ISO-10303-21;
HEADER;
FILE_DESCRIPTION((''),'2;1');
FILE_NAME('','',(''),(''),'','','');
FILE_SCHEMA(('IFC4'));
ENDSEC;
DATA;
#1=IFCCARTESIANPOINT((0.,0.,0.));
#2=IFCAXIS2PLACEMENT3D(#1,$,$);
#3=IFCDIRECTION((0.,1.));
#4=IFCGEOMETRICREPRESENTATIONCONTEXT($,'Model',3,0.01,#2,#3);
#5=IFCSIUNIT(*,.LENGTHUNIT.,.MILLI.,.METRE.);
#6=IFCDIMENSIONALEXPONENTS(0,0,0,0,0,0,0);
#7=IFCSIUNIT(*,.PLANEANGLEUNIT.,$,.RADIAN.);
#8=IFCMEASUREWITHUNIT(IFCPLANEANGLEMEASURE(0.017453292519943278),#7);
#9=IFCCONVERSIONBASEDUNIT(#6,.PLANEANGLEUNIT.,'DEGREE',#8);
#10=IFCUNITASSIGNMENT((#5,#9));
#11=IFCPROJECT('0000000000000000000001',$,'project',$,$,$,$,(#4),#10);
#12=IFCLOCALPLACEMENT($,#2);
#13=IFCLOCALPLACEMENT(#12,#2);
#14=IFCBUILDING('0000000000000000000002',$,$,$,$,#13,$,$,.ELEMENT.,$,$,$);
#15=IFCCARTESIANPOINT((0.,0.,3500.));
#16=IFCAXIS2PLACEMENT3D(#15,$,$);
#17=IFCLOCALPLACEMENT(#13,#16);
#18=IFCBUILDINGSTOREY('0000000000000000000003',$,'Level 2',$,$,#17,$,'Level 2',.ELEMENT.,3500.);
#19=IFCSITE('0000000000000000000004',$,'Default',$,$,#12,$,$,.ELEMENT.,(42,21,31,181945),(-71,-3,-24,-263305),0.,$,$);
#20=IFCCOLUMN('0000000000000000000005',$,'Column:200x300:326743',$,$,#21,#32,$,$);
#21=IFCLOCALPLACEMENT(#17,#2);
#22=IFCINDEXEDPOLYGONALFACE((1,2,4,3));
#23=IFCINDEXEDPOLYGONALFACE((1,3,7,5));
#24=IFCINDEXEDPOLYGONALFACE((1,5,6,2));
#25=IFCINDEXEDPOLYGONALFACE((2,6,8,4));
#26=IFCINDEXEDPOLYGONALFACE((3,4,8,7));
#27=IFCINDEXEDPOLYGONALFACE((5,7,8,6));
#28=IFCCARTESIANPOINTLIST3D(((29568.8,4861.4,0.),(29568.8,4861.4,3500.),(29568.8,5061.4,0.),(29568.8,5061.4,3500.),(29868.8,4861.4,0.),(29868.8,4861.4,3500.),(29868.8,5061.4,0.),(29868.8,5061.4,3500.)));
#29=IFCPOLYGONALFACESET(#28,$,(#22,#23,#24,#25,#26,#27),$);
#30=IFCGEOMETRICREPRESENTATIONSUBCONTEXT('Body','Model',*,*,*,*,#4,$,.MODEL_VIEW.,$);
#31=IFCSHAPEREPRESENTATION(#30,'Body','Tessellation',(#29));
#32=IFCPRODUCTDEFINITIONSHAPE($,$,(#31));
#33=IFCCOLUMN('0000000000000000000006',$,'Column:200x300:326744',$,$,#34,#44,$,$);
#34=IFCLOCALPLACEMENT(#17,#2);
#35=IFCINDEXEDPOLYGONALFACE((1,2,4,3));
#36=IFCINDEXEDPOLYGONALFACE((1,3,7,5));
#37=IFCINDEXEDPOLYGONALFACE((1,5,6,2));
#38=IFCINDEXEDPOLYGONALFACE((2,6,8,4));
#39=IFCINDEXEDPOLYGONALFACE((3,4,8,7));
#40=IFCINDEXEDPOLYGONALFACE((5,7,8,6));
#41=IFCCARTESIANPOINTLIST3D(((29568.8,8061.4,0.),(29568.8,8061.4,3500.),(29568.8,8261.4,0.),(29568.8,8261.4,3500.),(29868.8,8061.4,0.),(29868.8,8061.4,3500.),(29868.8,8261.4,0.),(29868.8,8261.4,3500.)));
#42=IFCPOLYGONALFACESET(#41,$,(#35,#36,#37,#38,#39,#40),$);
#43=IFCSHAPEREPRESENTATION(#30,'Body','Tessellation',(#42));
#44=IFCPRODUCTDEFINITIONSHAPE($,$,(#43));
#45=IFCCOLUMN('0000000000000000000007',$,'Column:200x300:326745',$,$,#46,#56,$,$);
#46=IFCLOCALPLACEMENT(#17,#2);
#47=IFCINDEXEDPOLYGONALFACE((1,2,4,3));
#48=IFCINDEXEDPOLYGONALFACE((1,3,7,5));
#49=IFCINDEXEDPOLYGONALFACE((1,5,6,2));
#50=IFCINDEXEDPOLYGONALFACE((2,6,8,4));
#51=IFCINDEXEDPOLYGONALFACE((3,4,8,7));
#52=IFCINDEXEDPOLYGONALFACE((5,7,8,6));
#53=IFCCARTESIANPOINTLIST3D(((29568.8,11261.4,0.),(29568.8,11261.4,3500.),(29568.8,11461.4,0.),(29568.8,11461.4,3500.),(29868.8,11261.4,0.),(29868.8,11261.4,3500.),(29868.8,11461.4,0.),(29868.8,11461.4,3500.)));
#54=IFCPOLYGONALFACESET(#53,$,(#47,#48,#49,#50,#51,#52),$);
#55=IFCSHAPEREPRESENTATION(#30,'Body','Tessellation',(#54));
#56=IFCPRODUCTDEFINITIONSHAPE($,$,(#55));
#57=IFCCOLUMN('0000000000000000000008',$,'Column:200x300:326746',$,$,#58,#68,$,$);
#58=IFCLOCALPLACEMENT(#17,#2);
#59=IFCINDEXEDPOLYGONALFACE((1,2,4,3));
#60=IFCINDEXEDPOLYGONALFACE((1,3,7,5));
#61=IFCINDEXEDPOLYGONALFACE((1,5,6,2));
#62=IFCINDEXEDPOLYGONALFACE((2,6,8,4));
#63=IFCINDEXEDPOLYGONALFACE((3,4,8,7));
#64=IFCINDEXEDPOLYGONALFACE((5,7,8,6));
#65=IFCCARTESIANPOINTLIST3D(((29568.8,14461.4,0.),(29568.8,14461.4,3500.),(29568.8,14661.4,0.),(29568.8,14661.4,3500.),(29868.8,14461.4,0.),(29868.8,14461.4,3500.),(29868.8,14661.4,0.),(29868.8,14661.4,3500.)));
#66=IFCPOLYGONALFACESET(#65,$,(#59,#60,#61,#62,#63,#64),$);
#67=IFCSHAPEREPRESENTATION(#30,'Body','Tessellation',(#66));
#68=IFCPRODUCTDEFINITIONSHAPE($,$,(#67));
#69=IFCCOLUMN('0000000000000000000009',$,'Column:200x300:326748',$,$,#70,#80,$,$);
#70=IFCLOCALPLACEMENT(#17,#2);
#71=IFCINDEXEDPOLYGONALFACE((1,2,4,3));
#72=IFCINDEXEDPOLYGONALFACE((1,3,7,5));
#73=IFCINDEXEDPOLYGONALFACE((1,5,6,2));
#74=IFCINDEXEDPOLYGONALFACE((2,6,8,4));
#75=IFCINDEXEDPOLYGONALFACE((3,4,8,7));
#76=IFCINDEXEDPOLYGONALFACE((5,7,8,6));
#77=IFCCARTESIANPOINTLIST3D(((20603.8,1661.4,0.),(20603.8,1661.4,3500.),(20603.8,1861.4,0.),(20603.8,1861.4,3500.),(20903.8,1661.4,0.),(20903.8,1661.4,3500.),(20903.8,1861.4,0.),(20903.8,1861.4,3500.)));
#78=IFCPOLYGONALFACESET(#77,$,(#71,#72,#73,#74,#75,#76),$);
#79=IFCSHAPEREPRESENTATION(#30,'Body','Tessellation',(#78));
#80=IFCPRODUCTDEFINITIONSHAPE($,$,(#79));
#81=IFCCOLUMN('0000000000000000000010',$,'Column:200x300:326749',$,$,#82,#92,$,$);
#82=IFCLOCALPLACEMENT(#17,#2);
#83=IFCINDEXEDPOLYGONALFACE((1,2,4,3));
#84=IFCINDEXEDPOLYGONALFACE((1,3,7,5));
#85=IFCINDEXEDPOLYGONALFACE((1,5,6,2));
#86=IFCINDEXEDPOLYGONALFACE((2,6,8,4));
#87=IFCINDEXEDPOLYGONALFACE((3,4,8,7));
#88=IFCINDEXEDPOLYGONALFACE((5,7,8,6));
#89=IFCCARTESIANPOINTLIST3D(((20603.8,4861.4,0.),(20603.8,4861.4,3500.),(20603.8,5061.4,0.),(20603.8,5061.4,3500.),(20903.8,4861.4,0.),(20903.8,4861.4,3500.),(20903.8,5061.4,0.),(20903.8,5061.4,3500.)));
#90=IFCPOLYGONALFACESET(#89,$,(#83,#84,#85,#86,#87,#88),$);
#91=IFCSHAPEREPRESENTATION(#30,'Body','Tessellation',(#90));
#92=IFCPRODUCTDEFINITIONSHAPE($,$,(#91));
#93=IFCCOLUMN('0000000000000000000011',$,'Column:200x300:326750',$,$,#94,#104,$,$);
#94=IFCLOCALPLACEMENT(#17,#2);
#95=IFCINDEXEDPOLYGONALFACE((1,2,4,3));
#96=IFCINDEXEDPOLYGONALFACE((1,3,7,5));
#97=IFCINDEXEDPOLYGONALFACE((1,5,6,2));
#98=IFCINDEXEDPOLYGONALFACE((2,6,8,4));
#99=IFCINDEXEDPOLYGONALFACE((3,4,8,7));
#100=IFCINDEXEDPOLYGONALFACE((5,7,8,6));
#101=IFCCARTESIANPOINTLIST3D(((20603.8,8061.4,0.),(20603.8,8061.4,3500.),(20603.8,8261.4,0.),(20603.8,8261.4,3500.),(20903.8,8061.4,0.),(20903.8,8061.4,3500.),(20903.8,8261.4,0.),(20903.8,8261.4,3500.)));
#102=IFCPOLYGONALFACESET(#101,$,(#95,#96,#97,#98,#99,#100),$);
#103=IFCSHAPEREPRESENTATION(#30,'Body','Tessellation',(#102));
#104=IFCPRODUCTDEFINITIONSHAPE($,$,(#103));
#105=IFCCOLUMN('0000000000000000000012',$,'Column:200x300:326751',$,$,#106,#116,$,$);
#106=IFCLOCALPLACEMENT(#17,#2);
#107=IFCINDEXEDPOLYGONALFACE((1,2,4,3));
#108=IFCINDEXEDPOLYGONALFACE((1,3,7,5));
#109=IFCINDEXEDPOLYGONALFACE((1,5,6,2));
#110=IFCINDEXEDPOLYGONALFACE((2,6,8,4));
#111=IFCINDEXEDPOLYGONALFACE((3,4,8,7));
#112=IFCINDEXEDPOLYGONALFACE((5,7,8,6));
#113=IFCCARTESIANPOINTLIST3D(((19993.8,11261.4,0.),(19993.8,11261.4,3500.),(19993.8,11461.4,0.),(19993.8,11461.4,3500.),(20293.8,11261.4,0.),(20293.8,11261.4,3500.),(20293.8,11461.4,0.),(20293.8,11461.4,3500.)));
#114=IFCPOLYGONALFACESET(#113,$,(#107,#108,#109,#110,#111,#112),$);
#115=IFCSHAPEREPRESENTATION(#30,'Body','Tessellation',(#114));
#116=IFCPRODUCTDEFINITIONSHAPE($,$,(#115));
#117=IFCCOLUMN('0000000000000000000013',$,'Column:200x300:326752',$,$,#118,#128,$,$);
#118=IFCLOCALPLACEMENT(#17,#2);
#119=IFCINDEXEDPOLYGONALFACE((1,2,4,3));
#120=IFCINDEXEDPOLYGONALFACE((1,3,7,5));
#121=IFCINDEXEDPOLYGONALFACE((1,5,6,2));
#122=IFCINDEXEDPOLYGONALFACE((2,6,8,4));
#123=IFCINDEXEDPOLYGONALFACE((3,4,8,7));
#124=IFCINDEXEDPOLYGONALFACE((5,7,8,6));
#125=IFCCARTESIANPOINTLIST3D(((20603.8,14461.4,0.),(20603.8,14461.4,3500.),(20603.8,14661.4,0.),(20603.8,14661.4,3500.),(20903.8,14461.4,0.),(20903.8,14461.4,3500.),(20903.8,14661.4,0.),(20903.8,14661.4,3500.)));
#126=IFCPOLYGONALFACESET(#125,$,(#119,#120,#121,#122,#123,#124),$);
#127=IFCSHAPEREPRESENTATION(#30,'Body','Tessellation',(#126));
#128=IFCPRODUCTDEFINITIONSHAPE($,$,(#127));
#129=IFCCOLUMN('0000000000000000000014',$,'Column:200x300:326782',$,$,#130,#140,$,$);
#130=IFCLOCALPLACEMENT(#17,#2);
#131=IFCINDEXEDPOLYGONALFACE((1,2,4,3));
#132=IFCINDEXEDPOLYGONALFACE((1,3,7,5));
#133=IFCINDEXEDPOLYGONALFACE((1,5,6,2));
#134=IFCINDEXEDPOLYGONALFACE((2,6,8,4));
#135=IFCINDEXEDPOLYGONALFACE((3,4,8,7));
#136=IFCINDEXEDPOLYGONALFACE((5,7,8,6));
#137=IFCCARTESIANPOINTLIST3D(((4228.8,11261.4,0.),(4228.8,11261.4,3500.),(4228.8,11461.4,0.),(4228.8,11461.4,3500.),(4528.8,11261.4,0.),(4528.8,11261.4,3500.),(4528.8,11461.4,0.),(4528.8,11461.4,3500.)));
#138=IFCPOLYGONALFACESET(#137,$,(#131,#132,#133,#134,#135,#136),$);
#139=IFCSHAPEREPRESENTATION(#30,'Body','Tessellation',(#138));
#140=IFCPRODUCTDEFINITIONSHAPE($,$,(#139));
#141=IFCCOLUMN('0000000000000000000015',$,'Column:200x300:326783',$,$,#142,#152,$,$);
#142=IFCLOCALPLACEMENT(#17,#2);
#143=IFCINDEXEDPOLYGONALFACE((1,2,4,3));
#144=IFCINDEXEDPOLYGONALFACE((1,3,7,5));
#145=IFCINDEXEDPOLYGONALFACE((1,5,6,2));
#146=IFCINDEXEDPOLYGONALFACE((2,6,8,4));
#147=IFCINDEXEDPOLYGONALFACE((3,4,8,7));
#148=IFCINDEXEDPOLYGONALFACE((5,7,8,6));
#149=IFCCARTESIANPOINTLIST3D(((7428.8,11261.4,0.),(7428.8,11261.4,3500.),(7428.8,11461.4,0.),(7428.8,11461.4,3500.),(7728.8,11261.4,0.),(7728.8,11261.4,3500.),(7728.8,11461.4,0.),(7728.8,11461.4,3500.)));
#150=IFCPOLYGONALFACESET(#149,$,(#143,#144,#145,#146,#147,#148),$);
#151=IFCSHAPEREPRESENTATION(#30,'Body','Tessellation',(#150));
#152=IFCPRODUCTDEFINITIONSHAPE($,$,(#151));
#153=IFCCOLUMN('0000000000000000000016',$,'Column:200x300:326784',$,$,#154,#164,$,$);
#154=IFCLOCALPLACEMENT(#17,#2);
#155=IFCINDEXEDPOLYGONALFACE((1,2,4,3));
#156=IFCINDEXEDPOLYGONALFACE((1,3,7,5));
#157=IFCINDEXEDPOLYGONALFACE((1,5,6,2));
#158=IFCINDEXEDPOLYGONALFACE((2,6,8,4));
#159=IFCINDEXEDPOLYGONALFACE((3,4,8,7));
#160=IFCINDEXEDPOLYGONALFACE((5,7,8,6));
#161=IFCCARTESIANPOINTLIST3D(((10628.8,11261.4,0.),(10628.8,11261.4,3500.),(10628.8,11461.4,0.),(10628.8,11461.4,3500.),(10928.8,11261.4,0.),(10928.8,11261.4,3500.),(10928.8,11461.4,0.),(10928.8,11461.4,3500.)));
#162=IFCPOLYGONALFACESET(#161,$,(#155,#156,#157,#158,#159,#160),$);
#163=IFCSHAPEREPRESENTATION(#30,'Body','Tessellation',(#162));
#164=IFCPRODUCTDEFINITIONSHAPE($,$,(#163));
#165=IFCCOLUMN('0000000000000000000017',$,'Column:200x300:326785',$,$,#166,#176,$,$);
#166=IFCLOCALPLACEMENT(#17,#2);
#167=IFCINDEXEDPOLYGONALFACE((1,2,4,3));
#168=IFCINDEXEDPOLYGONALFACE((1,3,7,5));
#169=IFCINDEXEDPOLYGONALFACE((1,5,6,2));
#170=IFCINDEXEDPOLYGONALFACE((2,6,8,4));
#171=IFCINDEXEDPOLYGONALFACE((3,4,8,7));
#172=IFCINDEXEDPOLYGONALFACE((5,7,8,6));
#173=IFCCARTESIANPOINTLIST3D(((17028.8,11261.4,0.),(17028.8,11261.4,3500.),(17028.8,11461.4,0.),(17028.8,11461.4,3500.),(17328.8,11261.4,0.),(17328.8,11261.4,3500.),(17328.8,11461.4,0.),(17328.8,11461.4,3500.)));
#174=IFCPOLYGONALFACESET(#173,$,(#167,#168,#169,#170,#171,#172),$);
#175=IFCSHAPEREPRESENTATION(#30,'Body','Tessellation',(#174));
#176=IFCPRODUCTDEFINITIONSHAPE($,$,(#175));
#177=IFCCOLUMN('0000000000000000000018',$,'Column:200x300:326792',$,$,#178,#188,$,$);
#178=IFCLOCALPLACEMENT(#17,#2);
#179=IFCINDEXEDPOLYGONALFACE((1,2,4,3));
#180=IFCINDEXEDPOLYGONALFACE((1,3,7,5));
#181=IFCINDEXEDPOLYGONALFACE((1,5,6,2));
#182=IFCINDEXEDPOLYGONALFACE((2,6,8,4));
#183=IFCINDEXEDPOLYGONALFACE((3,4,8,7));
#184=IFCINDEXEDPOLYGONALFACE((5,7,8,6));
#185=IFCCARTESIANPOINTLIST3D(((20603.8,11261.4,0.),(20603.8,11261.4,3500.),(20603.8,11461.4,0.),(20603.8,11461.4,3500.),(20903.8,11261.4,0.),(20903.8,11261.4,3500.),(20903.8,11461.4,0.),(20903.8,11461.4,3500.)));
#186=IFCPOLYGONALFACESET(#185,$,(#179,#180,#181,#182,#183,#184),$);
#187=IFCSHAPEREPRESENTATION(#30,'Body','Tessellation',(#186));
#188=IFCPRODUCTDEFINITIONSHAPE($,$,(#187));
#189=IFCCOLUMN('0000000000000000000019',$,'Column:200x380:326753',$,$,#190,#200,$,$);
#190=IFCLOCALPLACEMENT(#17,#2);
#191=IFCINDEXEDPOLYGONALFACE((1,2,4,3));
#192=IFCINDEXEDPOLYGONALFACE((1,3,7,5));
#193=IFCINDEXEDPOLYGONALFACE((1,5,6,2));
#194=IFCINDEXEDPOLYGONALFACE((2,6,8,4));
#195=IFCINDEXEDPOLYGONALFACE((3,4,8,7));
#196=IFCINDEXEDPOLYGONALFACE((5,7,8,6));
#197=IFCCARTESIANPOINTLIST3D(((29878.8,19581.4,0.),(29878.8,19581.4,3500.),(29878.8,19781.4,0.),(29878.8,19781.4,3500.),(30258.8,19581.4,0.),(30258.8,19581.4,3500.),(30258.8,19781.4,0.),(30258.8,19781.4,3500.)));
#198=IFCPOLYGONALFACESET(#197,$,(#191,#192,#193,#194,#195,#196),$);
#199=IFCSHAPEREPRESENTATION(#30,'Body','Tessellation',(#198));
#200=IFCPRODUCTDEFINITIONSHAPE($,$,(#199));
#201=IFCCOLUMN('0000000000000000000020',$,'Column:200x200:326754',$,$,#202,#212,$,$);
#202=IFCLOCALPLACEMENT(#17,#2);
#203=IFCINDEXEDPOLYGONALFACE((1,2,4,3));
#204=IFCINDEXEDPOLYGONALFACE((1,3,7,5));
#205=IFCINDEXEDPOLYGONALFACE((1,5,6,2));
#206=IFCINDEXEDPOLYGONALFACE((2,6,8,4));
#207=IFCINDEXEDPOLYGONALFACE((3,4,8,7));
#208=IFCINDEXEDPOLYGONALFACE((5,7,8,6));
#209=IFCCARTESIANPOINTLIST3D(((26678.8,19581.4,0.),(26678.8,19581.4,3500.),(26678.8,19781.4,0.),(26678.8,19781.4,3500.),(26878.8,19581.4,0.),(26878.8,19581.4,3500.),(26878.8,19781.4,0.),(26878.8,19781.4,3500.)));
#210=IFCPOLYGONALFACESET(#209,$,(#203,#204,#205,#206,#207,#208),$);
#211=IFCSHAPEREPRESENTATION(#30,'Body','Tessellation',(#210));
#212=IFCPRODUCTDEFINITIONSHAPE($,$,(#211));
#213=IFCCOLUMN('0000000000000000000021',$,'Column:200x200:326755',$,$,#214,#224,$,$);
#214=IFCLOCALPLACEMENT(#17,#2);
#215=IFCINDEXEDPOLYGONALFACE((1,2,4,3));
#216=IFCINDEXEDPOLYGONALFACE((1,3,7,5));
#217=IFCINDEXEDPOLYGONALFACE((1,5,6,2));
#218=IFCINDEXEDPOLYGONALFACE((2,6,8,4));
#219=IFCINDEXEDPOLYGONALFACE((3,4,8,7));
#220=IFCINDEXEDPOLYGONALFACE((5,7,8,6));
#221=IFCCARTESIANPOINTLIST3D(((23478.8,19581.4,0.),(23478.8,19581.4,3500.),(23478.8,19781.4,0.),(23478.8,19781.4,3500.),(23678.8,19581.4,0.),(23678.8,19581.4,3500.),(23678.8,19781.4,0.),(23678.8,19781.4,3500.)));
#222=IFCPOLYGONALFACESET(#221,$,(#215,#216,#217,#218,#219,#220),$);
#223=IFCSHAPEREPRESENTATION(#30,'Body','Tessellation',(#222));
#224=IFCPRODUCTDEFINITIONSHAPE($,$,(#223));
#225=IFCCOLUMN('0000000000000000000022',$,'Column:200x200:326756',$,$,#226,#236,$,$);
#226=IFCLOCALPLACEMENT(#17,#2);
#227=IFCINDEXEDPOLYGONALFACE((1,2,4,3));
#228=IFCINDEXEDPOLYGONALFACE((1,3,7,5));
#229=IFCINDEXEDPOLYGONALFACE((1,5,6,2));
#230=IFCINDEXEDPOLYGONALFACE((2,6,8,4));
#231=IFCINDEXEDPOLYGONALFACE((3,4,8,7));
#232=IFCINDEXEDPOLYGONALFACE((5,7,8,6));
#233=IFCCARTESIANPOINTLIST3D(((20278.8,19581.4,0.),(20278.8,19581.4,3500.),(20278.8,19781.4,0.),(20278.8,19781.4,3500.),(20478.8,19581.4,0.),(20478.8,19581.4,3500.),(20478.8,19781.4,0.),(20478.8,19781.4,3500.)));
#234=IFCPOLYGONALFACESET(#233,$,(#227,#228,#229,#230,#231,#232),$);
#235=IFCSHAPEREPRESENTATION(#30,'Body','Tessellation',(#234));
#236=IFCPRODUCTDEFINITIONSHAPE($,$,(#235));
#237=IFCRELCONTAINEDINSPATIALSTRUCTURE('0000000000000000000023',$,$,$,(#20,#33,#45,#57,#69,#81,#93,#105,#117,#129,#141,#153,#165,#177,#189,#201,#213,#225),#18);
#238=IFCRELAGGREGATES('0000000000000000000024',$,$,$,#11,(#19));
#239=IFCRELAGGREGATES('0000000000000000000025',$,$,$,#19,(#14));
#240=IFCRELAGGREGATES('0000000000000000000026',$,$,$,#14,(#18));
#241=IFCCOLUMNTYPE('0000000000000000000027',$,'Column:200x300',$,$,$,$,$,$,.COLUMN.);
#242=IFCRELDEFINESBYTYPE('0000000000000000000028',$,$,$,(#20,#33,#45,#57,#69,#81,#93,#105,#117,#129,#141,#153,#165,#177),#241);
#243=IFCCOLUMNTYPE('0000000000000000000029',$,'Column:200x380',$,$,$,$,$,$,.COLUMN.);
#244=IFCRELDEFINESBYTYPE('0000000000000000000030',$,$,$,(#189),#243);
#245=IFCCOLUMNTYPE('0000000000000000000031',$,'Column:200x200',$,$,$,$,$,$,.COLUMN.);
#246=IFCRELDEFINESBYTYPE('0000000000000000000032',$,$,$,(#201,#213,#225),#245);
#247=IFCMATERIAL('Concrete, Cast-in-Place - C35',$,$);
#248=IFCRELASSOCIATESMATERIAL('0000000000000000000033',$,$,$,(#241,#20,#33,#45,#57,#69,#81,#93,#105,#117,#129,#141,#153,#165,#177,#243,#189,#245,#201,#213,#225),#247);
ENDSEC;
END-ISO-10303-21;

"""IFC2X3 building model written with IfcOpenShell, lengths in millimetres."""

from ifc_helpers import new_model, entity, si_unit, converted_unit, direction, frame, frame_2d, origin, origin_2d_with_axis, place, context, subcontext, project, spatial, rectangle, extrude, source, transform, mapped, material, type_object, type_shapes, element, save


model = new_model("IFC2X3")

# Units and contexts
model_context = context("Model", 3, precision=0.01, world=origin(), true_north=direction((0.0, 1.0)))
body_context = subcontext(model_context, "Body", "Model", "MODEL_VIEW")
ifc_project = project(units=[si_unit("LENGTHUNIT", "METRE", prefix="MILLI"), converted_unit("PLANEANGLEUNIT", "DEGREE", entity("IfcPlaneAngleMeasure", 0.017453292519943278), si_unit("PLANEANGLEUNIT", "RADIAN"), dimensions=[0, 0, 0, 0, 0, 0, 0])], contexts=[model_context])

# Site, building, storey
site_placement = place(None, origin())
site = spatial("IfcSite", under=ifc_project, at=site_placement, Name="Default", CompositionType="ELEMENT", RefLatitude=(42, 21, 31, 181945), RefLongitude=(-71, -3, -24, -263305), RefElevation=0.0)
building_placement = place(site_placement, origin())
building = spatial("IfcBuilding", under=site, at=building_placement, CompositionType="ELEMENT")
storey_placement = place(building_placement, frame((0.0, 0.0, 3500.0)))
storey = spatial("IfcBuildingStorey", under=building, at=storey_placement, Name="Level 2", LongName="Level 2", CompositionType="ELEMENT", Elevation=3500.0)

# Columns
ifc_material = material(Name="Concrete, Cast-in-Place - C35")
column_type_1 = type_object("IfcColumnType", Name="Column:200x300", PredefinedType="COLUMN", material=ifc_material)
shared_shape_1 = source(origin(), body_context, "Body", "SweptSolid", [
    extrude(rectangle(XDim=300.0, YDim=200.0, at=origin_2d_with_axis()), frame((-50.0, 0.0, 3500.0), z_axis=(0.0, 0.0, 1.0), x_axis=(-1.0, 0.0, 0.0)), (0.0, 0.0, 1.0), 3500.0),
])
type_shapes(column_type_1, [shared_shape_1])
for number, where, name in (
    (1, (29768.8, 4961.4, -3500.0), "Column:200x300:326743"),
    (2, (29768.8, 8161.4, -3500.0), "Column:200x300:326744"),
    (3, (29768.8, 11361.4, -3500.0), "Column:200x300:326745"),
    (4, (29768.8, 14561.4, -3500.0), "Column:200x300:326746"),
    (5, (20803.8, 1761.4, -3500.0), "Column:200x300:326748"),
    (6, (20803.8, 4961.4, -3500.0), "Column:200x300:326749"),
    (7, (20803.8, 8161.4, -3500.0), "Column:200x300:326750"),
    (8, (20193.8, 11361.4, -3500.0), "Column:200x300:326751"),
    (9, (20803.8, 14561.4, -3500.0), "Column:200x300:326752"),
    (10, (4428.8, 11361.4, -3500.0), "Column:200x300:326782"),
    (11, (7628.8, 11361.4, -3500.0), "Column:200x300:326783"),
    (12, (10828.8, 11361.4, -3500.0), "Column:200x300:326784"),
    (13, (17228.8, 11361.4, -3500.0), "Column:200x300:326785"),
    (14, (20803.8, 11361.4, -3500.0), "Column:200x300:326792"),
):
    element("IfcColumn", number, at=place(storey_placement, frame(where)), inside=storey, type_object=column_type_1, material=ifc_material, Name=name, context=body_context, shape_type="MappedRepresentation", body=[
        mapped(shared_shape_1, transform((0.0, 0.0, 0.0), scale=1.0)),
    ])
column_type_2 = type_object("IfcColumnType", Name="Column:200x380", PredefinedType="COLUMN", material=ifc_material)
shared_shape_2 = source(origin(), body_context, "Body", "SweptSolid", [
    extrude(rectangle(XDim=380.0, YDim=200.0, at=origin_2d_with_axis()), frame((-90.0, 0.0, 3500.0), z_axis=(0.0, 0.0, 1.0), x_axis=(-1.0, 0.0, 0.0)), (0.0, 0.0, 1.0), 3500.0),
])
type_shapes(column_type_2, [shared_shape_2])
column_placement = place(storey_placement, frame((30158.8, 19681.4, -3500.0)))
element("IfcColumn", 15, at=column_placement, inside=storey, type_object=column_type_2, material=ifc_material, Name="Column:200x380:326753", context=body_context, shape_type="MappedRepresentation", body=[
    mapped(shared_shape_2, transform((0.0, 0.0, 0.0), scale=1.0)),
])
column_type_3 = type_object("IfcColumnType", Name="Column:200x200", PredefinedType="COLUMN", material=ifc_material)
shared_shape_3 = source(origin(), body_context, "Body", "SweptSolid", [
    extrude(rectangle(XDim=200.0, YDim=200.0, at=frame_2d((0.0, 0.0), x_axis=(1.0, 0.0))), frame((0.0, 0.0, 3500.0), z_axis=(0.0, 0.0, 1.0), x_axis=(-1.0, 0.0, 0.0)), (0.0, 0.0, 1.0), 3500.0),
])
type_shapes(column_type_3, [shared_shape_3])
for number, where, name in (
    (16, (26778.8, 19681.4, -3500.0), "Column:200x200:326754"),
    (17, (23578.8, 19681.4, -3500.0), "Column:200x200:326755"),
    (18, (20378.8, 19681.4, -3500.0), "Column:200x200:326756"),
):
    element("IfcColumn", number, at=place(storey_placement, frame(where)), inside=storey, type_object=column_type_3, material=ifc_material, Name=name, context=body_context, shape_type="MappedRepresentation", body=[
        mapped(shared_shape_3, transform((0.0, 0.0, 0.0), scale=1.0)),
    ])

save(model, "model.ifc")
